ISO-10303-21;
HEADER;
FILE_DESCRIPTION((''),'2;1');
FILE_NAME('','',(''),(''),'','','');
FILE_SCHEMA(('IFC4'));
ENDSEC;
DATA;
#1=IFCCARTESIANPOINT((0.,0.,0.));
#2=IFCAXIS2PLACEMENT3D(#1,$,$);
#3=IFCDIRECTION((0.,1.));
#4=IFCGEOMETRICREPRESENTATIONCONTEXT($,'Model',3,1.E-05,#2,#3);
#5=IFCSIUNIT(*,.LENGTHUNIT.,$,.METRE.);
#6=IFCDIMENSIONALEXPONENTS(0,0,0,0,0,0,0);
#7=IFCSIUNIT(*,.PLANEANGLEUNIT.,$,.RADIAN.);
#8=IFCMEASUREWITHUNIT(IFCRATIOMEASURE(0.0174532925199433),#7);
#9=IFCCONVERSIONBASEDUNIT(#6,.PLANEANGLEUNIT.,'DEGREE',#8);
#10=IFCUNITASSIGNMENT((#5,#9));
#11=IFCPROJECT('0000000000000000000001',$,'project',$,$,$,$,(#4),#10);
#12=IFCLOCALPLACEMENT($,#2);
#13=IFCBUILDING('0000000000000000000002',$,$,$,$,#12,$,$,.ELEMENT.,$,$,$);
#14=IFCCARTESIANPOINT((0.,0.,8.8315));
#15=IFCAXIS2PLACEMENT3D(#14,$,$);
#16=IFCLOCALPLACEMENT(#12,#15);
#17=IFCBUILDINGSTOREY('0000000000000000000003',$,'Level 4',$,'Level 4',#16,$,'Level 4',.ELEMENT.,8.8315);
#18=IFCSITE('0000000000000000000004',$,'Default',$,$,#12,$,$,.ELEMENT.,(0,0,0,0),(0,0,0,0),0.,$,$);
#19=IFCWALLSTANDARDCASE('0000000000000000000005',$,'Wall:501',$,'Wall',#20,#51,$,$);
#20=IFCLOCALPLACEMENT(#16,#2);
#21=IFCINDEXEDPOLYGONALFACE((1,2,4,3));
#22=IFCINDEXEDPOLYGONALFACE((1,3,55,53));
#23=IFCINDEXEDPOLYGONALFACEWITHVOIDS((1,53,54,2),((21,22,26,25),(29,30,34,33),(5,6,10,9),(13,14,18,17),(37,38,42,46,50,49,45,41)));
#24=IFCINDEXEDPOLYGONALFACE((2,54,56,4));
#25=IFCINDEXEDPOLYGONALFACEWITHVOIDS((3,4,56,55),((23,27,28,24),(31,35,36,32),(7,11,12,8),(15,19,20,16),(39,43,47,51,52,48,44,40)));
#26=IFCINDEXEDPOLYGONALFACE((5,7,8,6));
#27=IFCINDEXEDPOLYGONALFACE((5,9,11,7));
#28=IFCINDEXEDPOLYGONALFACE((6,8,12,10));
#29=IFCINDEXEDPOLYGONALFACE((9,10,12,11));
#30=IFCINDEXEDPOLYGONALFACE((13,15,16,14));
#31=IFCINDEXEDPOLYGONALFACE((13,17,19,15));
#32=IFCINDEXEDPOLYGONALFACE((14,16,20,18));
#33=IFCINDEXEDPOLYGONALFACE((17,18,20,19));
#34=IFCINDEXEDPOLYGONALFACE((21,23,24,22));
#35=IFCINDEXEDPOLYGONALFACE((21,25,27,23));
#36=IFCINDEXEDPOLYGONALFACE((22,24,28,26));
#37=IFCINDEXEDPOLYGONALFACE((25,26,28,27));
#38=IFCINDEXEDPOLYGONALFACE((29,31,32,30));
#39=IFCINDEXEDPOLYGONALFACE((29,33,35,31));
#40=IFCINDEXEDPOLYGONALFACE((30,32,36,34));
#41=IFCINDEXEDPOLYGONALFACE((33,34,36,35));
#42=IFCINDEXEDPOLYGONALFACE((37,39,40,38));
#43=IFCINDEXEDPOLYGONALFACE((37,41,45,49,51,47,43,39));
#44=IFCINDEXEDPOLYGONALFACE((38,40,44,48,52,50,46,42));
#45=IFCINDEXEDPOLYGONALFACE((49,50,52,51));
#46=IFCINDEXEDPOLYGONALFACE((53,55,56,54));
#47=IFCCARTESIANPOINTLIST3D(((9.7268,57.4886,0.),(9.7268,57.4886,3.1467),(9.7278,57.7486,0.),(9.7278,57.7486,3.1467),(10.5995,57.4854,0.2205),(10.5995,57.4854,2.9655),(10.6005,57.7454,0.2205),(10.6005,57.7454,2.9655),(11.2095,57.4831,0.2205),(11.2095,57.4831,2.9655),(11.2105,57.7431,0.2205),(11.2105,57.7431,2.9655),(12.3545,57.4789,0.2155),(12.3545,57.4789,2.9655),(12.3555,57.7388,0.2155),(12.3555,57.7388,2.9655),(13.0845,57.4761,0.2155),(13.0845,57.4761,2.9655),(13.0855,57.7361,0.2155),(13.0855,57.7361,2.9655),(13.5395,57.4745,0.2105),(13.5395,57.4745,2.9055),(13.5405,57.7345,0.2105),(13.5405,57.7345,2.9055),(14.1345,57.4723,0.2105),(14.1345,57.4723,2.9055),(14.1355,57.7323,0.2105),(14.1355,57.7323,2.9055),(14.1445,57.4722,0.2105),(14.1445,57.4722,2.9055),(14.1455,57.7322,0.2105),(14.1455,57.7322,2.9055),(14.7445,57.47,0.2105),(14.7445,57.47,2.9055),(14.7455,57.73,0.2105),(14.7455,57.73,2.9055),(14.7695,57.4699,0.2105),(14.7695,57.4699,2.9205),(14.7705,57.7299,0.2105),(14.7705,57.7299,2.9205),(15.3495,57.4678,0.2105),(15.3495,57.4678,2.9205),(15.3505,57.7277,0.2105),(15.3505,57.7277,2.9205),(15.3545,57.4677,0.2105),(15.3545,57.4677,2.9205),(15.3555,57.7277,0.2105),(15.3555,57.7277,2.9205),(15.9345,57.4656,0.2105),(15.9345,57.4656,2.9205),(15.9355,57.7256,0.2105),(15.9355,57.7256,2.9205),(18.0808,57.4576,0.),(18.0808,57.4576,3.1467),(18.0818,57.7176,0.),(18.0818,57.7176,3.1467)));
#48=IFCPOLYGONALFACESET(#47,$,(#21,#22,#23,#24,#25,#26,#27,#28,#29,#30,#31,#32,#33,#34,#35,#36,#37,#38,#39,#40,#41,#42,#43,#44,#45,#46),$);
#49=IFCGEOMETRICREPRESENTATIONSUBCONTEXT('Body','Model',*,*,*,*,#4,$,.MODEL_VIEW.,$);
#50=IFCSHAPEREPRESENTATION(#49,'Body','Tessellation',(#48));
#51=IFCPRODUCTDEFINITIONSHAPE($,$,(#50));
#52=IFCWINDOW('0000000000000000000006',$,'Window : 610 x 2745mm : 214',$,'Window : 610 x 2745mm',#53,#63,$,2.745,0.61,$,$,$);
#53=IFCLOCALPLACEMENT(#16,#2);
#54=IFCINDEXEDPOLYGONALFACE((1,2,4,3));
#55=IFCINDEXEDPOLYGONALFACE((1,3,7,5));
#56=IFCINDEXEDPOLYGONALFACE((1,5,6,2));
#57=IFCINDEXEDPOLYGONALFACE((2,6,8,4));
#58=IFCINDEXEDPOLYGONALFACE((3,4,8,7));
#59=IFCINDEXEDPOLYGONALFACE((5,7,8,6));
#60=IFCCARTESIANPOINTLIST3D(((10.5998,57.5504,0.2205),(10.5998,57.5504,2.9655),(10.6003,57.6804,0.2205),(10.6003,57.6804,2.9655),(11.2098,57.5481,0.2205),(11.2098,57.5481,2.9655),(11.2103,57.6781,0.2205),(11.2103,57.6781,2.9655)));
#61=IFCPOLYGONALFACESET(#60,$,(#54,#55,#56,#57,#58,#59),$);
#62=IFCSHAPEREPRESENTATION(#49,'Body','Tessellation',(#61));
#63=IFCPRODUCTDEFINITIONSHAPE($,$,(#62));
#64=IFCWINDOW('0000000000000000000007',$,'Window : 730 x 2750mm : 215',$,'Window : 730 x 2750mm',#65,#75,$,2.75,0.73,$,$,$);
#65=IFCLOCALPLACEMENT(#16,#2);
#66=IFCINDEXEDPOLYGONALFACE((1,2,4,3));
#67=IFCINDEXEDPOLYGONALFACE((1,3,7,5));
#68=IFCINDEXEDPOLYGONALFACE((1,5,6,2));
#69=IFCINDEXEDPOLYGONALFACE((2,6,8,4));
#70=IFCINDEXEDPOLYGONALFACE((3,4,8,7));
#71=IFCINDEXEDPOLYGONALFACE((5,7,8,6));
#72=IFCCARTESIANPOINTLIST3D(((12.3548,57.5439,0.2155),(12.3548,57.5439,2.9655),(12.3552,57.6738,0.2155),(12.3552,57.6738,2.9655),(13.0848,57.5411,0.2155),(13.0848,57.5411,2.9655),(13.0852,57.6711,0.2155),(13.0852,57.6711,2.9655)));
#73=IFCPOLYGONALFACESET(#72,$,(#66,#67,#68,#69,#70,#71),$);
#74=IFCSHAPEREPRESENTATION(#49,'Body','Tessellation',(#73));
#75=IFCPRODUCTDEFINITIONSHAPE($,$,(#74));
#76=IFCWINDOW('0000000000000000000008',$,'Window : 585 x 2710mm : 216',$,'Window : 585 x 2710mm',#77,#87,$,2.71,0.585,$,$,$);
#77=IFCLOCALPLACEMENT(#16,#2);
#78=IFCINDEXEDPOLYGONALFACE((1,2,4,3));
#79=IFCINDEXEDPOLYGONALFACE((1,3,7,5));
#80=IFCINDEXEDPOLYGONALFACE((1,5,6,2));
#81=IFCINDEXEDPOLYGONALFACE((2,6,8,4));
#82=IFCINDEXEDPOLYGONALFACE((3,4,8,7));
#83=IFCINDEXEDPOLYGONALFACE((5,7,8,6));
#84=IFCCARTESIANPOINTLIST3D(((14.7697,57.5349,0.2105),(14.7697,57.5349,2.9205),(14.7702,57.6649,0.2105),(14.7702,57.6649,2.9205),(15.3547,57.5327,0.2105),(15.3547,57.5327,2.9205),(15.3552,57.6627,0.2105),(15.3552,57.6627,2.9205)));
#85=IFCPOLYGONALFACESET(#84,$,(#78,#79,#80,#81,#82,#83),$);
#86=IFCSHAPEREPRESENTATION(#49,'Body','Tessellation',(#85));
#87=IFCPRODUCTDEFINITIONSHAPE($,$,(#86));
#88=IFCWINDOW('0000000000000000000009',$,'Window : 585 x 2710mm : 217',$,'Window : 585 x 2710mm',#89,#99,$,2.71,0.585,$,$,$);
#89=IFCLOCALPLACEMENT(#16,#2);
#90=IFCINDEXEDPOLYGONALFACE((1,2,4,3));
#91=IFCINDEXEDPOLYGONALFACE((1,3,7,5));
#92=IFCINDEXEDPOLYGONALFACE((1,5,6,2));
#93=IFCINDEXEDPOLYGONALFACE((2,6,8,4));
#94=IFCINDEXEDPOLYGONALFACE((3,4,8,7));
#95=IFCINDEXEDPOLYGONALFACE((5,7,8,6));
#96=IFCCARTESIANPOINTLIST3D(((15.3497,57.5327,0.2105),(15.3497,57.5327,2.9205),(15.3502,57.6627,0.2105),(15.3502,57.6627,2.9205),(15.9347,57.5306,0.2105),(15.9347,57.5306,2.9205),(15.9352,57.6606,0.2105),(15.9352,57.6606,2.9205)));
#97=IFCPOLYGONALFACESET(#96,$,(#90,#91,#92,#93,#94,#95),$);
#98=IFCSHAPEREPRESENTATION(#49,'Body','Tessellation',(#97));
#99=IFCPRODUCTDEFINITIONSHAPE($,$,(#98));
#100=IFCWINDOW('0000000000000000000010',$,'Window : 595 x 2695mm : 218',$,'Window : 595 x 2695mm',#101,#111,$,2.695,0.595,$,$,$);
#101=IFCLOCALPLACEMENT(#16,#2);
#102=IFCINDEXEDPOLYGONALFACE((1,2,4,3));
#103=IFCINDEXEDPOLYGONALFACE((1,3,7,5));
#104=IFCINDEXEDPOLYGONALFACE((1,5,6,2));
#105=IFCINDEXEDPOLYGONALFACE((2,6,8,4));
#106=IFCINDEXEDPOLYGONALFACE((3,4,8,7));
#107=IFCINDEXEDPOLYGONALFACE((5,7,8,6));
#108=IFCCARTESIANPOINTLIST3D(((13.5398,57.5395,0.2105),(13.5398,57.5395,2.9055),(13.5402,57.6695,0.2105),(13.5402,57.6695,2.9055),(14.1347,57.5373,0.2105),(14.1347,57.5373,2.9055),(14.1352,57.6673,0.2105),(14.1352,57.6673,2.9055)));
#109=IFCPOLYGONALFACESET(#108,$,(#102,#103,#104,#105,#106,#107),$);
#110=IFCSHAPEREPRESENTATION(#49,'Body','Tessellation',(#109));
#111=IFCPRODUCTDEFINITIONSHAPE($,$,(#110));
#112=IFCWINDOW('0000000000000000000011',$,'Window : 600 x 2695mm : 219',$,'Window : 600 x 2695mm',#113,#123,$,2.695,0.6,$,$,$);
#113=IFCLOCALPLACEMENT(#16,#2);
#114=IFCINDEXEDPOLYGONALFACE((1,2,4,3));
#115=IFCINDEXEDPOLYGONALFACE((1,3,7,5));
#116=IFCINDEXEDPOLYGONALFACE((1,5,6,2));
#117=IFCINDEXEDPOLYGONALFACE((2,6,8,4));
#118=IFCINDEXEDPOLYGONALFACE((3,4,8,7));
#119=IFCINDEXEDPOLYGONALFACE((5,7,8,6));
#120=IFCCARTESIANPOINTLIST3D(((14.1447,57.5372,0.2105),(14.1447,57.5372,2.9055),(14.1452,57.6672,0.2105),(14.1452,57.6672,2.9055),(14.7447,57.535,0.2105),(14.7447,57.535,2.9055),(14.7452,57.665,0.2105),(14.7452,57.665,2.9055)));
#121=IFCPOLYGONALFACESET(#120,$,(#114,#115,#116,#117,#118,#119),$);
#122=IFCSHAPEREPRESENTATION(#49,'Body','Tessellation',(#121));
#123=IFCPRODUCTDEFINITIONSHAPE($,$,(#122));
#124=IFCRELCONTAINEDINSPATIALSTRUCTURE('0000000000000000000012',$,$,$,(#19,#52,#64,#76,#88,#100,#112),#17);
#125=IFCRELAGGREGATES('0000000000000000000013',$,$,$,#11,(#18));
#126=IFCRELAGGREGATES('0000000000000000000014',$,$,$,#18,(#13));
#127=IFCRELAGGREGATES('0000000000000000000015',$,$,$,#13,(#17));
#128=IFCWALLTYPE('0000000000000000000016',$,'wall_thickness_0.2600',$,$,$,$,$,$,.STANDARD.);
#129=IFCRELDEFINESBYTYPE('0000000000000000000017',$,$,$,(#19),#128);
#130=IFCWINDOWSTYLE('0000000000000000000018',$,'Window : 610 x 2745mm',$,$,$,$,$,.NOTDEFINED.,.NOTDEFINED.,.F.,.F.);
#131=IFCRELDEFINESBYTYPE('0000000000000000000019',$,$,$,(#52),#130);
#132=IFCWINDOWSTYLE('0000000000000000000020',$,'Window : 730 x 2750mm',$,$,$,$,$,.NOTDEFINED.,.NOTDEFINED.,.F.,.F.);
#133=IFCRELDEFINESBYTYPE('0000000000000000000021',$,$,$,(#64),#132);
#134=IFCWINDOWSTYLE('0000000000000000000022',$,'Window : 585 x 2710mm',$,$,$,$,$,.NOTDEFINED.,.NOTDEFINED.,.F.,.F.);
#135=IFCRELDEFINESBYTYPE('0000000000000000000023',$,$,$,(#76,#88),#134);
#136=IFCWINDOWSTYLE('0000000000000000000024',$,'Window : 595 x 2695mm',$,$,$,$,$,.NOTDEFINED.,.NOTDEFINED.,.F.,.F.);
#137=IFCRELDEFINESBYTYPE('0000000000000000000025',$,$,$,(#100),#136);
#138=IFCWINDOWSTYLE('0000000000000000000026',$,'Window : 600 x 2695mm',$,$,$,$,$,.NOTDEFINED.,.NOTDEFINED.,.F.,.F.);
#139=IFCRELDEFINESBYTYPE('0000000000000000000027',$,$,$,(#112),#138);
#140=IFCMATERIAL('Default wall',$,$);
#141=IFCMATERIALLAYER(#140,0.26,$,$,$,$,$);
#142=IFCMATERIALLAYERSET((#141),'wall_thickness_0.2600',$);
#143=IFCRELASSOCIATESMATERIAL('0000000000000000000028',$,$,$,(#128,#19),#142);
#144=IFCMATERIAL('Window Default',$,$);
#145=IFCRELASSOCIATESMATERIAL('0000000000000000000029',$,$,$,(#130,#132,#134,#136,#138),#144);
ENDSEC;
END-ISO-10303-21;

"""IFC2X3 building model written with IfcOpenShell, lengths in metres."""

from ifc_helpers import new_model, entity, si_unit, converted_unit, direction, frame, frame_2d, origin, origin_2d_with_axis, place, context, subcontext, project, spatial, polyline, rectangle, outline, extrude, source, transform, mapped, material, layer, layer_set, layer_usage, type_object, type_shapes, element, fill, save


model = new_model("IFC2X3")

# Units and contexts
model_context = context("Model", 3, precision=1e-05, world=origin(), true_north=direction((0.0, 1.0)))
body_context = subcontext(model_context, "Body", "Model", "MODEL_VIEW")
ifc_project = project(units=[si_unit("LENGTHUNIT", "METRE"), converted_unit("PLANEANGLEUNIT", "DEGREE", entity("IfcRatioMeasure", 0.0174532925199433), si_unit("PLANEANGLEUNIT", "RADIAN"), dimensions=[0, 0, 0, 0, 0, 0, 0])], contexts=[model_context])

# Site, building, storey
placement = place(None, origin())
site = spatial("IfcSite", under=ifc_project, at=placement, Name="Default", CompositionType="ELEMENT", RefLatitude=(0, 0, 0, 0), RefLongitude=(0, 0, 0, 0), RefElevation=0.0)
building = spatial("IfcBuilding", under=site, at=placement, CompositionType="ELEMENT")
storey_placement = place(placement, frame((0.0, 0.0, 8.8315)))
storey = spatial("IfcBuildingStorey", under=building, at=storey_placement, Name="Level 4", ObjectType="Level 4", LongName="Level 4", CompositionType="ELEMENT", Elevation=8.8315)

# Shared definitions
ifc_material_1 = material(Name="Default wall")

# Wall, openings, windows
ifc_layer_1 = layer(ifc_material_1, 0.26)
ifc_layer_set_1 = layer_set([ifc_layer_1], Name="wall_thickness_0.2600")
ifc_layer_usage_1 = layer_usage(ifc_layer_set_1, "AXIS2", "POSITIVE", -0.13)
wall_type_1 = type_object("IfcWallType", Name="wall_thickness_0.2600", PredefinedType="STANDARD", material=ifc_layer_set_1)
wall_1_placement = place(storey_placement, frame((9.7273, 57.6186, 0.0), z_axis=(0.0, 0.0, 1.0), x_axis=(0.999993, -0.003706, 0.0)))
wall_1 = element("IfcWallStandardCase", 1, at=wall_1_placement, inside=storey, type_object=wall_type_1, material=ifc_layer_usage_1, Name="Wall:501", ObjectType="Wall", context=body_context, shape_type="SweptSolid", body=[
    extrude(outline(polyline([(8.3541, -0.13), (8.3541, 0.13), (0.0, 0.13), (0.0, -0.13), (8.3541, -0.13)])), origin(), (0.0, 0.0, 1.0), 3.1467),
])
opening_1_placement = place(wall_1_placement, frame((0.8727, -0.13, 0.2205)))
opening_1 = element("IfcOpeningElement", 2, at=opening_1_placement, cuts=wall_1, ObjectType="Opening", context=body_context, shape_type="SweptSolid", body=[
    extrude(rectangle(XDim=0.61, YDim=2.745, at=frame_2d((1.3725, 0.305), x_axis=(0.0, 1.0))), frame((0.0, 0.0, 0.0), z_axis=(0.0, 1.0, 0.0), x_axis=(0.0, 0.0, 1.0)), (0.0, 0.0, 1.0), 0.26),
])
opening_2_placement = place(wall_1_placement, frame((2.6277, -0.13, 0.2155)))
opening_2 = element("IfcOpeningElement", 3, at=opening_2_placement, cuts=wall_1, ObjectType="Opening", context=body_context, shape_type="SweptSolid", body=[
    extrude(rectangle(XDim=0.73, YDim=2.75, at=frame_2d((1.375, 0.365), x_axis=(0.0, 1.0))), frame((0.0, 0.0, 0.0), z_axis=(0.0, 1.0, 0.0), x_axis=(0.0, 0.0, 1.0)), (0.0, 0.0, 1.0), 0.26),
])
opening_3_placement = place(wall_1_placement, frame((5.0427, -0.13, 0.2105)))
opening_3 = element("IfcOpeningElement", 4, at=opening_3_placement, cuts=wall_1, ObjectType="Opening", context=body_context, shape_type="SweptSolid", body=[
    extrude(rectangle(XDim=0.585, YDim=2.71, at=frame_2d((1.355, 0.2925), x_axis=(0.0, 1.0))), frame((0.0, 0.0, 0.0), z_axis=(0.0, 1.0, 0.0), x_axis=(0.0, 0.0, 1.0)), (0.0, 0.0, 1.0), 0.26),
])
opening_4_placement = place(wall_1_placement, frame((5.6227, -0.13, 0.2105)))
opening_4 = element("IfcOpeningElement", 5, at=opening_4_placement, cuts=wall_1, ObjectType="Opening", context=body_context, shape_type="SweptSolid", body=[
    extrude(rectangle(XDim=0.585, YDim=2.71, at=frame_2d((1.355, 0.2925), x_axis=(0.0, 1.0))), frame((0.0, 0.0, 0.0), z_axis=(0.0, 1.0, 0.0), x_axis=(0.0, 0.0, 1.0)), (0.0, 0.0, 1.0), 0.26),
])
opening_5_placement = place(wall_1_placement, frame((3.8127, -0.13, 0.2105)))
opening_5 = element("IfcOpeningElement", 6, at=opening_5_placement, cuts=wall_1, ObjectType="Opening", context=body_context, shape_type="SweptSolid", body=[
    extrude(rectangle(XDim=0.595, YDim=2.695, at=frame_2d((1.3475, 0.2975), x_axis=(0.0, 1.0))), frame((0.0, 0.0, 0.0), z_axis=(0.0, 1.0, 0.0), x_axis=(0.0, 0.0, 1.0)), (0.0, 0.0, 1.0), 0.26),
])
opening_6_placement = place(wall_1_placement, frame((4.4177, -0.13, 0.2105)))
opening_6 = element("IfcOpeningElement", 7, at=opening_6_placement, cuts=wall_1, ObjectType="Opening", context=body_context, shape_type="SweptSolid", body=[
    extrude(rectangle(XDim=0.6, YDim=2.695, at=frame_2d((1.3475, 0.3), x_axis=(0.0, 1.0))), frame((0.0, 0.0, 0.0), z_axis=(0.0, 1.0, 0.0), x_axis=(0.0, 0.0, 1.0)), (0.0, 0.0, 1.0), 0.26),
])
ifc_material_2 = material(Name="Window Default")
window_style_1 = type_object("IfcWindowStyle", Name="Window : 610 x 2745mm", ConstructionType="NOTDEFINED", OperationType="NOTDEFINED", ParameterTakesPrecedence=False, Sizeable=False, material=ifc_material_2)
shared_shape_1 = source(origin(), body_context, "Body", "SweptSolid", [
    extrude(rectangle(XDim=0.13, YDim=0.61, at=origin_2d_with_axis()), frame((0.305, 0.13, 0.0), z_axis=(0.0, 0.0, 1.0), x_axis=(0.0, 1.0, 0.0)), (0.0, 0.0, 1.0), 2.745),
])
type_shapes(window_style_1, [shared_shape_1])
window_1_placement = place(opening_1_placement, origin())
window_1 = element("IfcWindow", 8, at=window_1_placement, inside=storey, type_object=window_style_1, Name="Window : 610 x 2745mm : 214", ObjectType="Window : 610 x 2745mm", OverallHeight=2.745, OverallWidth=0.61, context=body_context, shape_type="MappedRepresentation", body=[
    mapped(shared_shape_1, transform((0.0, 0.0, 0.0), scale=1.0)),
])
fill(opening_1, window_1)
window_style_2 = type_object("IfcWindowStyle", Name="Window : 730 x 2750mm", ConstructionType="NOTDEFINED", OperationType="NOTDEFINED", ParameterTakesPrecedence=False, Sizeable=False, material=ifc_material_2)
shared_shape_2 = source(origin(), body_context, "Body", "SweptSolid", [
    extrude(rectangle(XDim=0.13, YDim=0.73, at=origin_2d_with_axis()), frame((0.365, 0.13, 0.0), z_axis=(0.0, 0.0, 1.0), x_axis=(0.0, 1.0, 0.0)), (0.0, 0.0, 1.0), 2.75),
])
type_shapes(window_style_2, [shared_shape_2])
window_2_placement = place(opening_2_placement, origin())
window_2 = element("IfcWindow", 9, at=window_2_placement, inside=storey, type_object=window_style_2, Name="Window : 730 x 2750mm : 215", ObjectType="Window : 730 x 2750mm", OverallHeight=2.75, OverallWidth=0.73, context=body_context, shape_type="MappedRepresentation", body=[
    mapped(shared_shape_2, transform((0.0, 0.0, 0.0), scale=1.0)),
])
fill(opening_2, window_2)
window_style_3 = type_object("IfcWindowStyle", Name="Window : 585 x 2710mm", ConstructionType="NOTDEFINED", OperationType="NOTDEFINED", ParameterTakesPrecedence=False, Sizeable=False, material=ifc_material_2)
shared_shape_3 = source(origin(), body_context, "Body", "SweptSolid", [
    extrude(rectangle(XDim=0.13, YDim=0.585, at=origin_2d_with_axis()), frame((0.2925, 0.13, 0.0), z_axis=(0.0, 0.0, 1.0), x_axis=(0.0, 1.0, 0.0)), (0.0, 0.0, 1.0), 2.71),
])
type_shapes(window_style_3, [shared_shape_3])
window_3_placement = place(opening_3_placement, origin())
window_3 = element("IfcWindow", 10, at=window_3_placement, inside=storey, type_object=window_style_3, Name="Window : 585 x 2710mm : 216", ObjectType="Window : 585 x 2710mm", OverallHeight=2.71, OverallWidth=0.585, context=body_context, shape_type="MappedRepresentation", body=[
    mapped(shared_shape_3, transform((0.0, 0.0, 0.0), scale=1.0)),
])
fill(opening_3, window_3)
window_4_placement = place(opening_4_placement, origin())
window_4 = element("IfcWindow", 11, at=window_4_placement, inside=storey, type_object=window_style_3, Name="Window : 585 x 2710mm : 217", ObjectType="Window : 585 x 2710mm", OverallHeight=2.71, OverallWidth=0.585, context=body_context, shape_type="MappedRepresentation", body=[
    mapped(shared_shape_3, transform((0.0, 0.0, 0.0), scale=1.0)),
])
fill(opening_4, window_4)
window_style_4 = type_object("IfcWindowStyle", Name="Window : 595 x 2695mm", ConstructionType="NOTDEFINED", OperationType="NOTDEFINED", ParameterTakesPrecedence=False, Sizeable=False, material=ifc_material_2)
shared_shape_4 = source(origin(), body_context, "Body", "SweptSolid", [
    extrude(rectangle(XDim=0.13, YDim=0.595, at=origin_2d_with_axis()), frame((0.2975, 0.13, 0.0), z_axis=(0.0, 0.0, 1.0), x_axis=(0.0, 1.0, 0.0)), (0.0, 0.0, 1.0), 2.695),
])
type_shapes(window_style_4, [shared_shape_4])
window_5_placement = place(opening_5_placement, origin())
window_5 = element("IfcWindow", 12, at=window_5_placement, inside=storey, type_object=window_style_4, Name="Window : 595 x 2695mm : 218", ObjectType="Window : 595 x 2695mm", OverallHeight=2.695, OverallWidth=0.595, context=body_context, shape_type="MappedRepresentation", body=[
    mapped(shared_shape_4, transform((0.0, 0.0, 0.0), scale=1.0)),
])
fill(opening_5, window_5)
window_style_5 = type_object("IfcWindowStyle", Name="Window : 600 x 2695mm", ConstructionType="NOTDEFINED", OperationType="NOTDEFINED", ParameterTakesPrecedence=False, Sizeable=False, material=ifc_material_2)
shared_shape_5 = source(origin(), body_context, "Body", "SweptSolid", [
    extrude(rectangle(XDim=0.13, YDim=0.6, at=origin_2d_with_axis()), frame((0.3, 0.13, 0.0), z_axis=(0.0, 0.0, 1.0), x_axis=(0.0, 1.0, 0.0)), (0.0, 0.0, 1.0), 2.695),
])
type_shapes(window_style_5, [shared_shape_5])
window_6_placement = place(opening_6_placement, origin())
window_6 = element("IfcWindow", 13, at=window_6_placement, inside=storey, type_object=window_style_5, Name="Window : 600 x 2695mm : 219", ObjectType="Window : 600 x 2695mm", OverallHeight=2.695, OverallWidth=0.6, context=body_context, shape_type="MappedRepresentation", body=[
    mapped(shared_shape_5, transform((0.0, 0.0, 0.0), scale=1.0)),
])
fill(opening_6, window_6)

save(model, "model.ifc")
